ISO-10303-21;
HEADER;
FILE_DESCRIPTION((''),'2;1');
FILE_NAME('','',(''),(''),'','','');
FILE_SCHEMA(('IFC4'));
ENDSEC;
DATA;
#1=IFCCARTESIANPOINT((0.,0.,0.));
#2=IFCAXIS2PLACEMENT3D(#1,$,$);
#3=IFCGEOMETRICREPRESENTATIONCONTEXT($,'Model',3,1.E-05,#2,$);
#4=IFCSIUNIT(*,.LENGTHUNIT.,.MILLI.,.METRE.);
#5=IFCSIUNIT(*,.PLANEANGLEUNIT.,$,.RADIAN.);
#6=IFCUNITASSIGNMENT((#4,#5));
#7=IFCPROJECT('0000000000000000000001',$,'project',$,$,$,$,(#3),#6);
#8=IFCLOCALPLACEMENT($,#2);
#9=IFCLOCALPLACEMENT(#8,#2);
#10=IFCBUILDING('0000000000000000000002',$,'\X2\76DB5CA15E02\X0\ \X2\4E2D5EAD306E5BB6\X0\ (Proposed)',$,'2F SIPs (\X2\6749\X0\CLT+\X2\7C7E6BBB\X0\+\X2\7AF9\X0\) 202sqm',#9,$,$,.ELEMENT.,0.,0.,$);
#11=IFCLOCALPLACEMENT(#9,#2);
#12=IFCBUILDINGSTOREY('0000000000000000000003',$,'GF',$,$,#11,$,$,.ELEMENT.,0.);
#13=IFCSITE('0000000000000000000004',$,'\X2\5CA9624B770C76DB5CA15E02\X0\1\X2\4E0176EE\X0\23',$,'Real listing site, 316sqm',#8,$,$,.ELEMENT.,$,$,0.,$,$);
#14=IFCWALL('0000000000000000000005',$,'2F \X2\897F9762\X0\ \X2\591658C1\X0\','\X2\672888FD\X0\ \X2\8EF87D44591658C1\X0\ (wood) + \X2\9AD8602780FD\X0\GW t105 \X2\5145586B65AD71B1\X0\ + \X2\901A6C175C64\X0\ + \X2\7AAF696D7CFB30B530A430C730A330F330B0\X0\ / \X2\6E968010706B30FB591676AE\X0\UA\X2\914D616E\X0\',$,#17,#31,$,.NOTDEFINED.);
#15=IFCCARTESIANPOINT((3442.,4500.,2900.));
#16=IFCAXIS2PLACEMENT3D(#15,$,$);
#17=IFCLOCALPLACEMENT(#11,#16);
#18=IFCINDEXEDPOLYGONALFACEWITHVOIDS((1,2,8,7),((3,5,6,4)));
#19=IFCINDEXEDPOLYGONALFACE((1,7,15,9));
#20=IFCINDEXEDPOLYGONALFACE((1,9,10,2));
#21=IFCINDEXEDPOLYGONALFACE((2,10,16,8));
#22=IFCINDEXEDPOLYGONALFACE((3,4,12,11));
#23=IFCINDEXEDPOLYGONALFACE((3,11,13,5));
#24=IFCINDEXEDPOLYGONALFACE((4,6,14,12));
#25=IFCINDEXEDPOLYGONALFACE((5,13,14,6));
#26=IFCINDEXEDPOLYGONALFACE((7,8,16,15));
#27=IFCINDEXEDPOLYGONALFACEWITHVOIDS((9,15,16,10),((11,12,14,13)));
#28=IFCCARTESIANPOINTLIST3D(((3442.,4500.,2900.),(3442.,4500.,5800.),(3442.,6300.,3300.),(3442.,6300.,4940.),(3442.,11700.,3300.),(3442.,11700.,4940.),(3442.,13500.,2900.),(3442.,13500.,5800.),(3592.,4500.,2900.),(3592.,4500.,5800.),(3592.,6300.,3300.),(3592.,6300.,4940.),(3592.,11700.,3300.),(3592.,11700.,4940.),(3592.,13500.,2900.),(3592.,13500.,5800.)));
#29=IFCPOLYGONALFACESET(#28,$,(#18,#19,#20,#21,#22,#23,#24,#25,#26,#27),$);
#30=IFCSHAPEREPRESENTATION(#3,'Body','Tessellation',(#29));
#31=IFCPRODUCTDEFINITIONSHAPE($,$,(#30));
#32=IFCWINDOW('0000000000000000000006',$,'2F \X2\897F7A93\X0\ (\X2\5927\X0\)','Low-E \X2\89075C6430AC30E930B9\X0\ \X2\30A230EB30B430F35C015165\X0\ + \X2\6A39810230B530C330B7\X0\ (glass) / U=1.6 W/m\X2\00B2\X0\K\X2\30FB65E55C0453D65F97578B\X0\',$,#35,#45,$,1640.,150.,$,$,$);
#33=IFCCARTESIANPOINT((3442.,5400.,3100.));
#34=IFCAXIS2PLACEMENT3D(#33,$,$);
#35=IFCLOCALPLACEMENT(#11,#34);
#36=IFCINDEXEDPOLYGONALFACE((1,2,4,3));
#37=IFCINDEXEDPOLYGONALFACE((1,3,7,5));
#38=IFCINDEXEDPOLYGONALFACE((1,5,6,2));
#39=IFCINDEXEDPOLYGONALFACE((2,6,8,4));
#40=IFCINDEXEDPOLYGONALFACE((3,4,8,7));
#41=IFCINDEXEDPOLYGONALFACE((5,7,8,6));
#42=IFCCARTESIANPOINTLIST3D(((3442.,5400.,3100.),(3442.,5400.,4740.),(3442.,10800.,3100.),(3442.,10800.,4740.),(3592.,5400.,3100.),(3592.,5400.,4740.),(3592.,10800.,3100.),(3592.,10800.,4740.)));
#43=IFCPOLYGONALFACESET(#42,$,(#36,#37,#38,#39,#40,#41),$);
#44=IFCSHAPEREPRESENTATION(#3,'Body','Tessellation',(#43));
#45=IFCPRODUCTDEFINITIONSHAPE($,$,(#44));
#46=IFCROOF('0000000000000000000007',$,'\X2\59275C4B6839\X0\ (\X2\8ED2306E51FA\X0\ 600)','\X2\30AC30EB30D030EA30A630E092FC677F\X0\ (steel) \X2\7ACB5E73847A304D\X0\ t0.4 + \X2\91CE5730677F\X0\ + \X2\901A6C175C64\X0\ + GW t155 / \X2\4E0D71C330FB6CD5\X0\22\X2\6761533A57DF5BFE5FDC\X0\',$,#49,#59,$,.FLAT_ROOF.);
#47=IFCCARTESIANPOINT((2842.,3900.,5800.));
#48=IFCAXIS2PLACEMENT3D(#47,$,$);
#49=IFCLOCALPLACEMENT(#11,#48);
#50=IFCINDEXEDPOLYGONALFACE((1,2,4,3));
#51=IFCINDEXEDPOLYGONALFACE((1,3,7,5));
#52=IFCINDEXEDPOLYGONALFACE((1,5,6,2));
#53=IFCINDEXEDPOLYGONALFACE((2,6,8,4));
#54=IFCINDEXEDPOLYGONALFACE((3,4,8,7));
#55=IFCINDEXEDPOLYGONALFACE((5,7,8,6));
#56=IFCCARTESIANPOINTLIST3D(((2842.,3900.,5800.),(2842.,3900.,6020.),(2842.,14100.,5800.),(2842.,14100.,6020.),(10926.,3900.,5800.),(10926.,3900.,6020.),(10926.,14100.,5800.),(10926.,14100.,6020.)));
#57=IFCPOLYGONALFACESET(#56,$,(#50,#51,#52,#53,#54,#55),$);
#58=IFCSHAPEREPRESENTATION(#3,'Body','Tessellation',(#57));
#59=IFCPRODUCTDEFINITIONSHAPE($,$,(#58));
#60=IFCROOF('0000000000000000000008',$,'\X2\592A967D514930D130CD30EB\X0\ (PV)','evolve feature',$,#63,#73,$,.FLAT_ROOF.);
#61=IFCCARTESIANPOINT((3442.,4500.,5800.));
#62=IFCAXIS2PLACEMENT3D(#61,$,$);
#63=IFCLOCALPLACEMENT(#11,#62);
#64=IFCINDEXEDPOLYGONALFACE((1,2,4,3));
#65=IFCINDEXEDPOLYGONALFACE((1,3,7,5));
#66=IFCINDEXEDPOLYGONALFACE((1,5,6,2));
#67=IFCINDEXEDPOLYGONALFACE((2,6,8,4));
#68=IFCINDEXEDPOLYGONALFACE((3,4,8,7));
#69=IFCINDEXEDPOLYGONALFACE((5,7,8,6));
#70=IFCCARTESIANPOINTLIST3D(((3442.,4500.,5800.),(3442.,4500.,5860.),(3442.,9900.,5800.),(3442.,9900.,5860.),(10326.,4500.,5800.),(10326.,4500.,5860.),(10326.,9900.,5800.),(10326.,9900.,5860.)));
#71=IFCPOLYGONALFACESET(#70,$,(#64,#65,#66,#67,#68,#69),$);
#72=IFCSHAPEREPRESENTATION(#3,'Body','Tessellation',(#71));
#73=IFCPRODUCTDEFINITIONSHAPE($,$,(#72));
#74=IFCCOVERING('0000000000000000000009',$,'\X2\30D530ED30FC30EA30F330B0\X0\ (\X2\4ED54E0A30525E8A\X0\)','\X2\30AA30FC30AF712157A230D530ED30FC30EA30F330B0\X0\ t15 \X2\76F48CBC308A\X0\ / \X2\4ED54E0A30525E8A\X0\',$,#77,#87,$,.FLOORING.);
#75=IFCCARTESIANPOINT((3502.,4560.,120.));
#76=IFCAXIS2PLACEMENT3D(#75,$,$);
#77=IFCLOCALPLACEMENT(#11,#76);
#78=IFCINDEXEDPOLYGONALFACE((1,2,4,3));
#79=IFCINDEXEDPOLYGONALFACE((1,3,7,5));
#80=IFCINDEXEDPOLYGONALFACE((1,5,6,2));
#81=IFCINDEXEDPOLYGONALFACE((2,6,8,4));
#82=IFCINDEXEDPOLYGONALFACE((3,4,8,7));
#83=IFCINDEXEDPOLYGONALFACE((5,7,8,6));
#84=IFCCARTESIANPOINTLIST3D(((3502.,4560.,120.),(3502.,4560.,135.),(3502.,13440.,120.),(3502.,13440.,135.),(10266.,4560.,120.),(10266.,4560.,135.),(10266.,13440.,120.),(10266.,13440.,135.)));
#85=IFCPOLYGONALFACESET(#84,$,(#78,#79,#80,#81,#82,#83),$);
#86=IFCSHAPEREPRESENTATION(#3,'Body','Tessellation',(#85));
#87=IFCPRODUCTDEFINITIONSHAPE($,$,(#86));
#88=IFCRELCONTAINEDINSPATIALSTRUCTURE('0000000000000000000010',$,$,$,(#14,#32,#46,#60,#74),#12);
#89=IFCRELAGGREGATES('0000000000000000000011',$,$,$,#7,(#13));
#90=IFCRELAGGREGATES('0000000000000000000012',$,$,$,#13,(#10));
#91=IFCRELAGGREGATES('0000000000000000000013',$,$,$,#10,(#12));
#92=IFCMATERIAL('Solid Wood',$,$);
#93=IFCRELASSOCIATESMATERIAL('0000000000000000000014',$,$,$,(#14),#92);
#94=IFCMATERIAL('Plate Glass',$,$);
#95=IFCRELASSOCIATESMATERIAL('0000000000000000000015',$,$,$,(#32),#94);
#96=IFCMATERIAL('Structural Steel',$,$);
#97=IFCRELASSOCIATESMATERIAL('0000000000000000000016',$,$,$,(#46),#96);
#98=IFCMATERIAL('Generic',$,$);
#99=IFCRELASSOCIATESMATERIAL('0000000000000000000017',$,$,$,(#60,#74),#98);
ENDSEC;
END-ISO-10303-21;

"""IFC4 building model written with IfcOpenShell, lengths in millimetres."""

from ifc_helpers import new_model, si_unit, frame, frame_2d, origin, place, context, project, spatial, rectangle, extrude, material, element, fill, save


model = new_model("IFC4")

# Units and contexts
model_context = context("Model", 3, precision=1e-05, world=origin())
ifc_project = project(units=[si_unit("LENGTHUNIT", "METRE", prefix="MILLI"), si_unit("PLANEANGLEUNIT", "RADIAN")], contexts=[model_context])

# Site, building, storey
site_placement = place(None, origin())
site = spatial("IfcSite", under=ifc_project, at=site_placement, Name="岩手県盛岡市1丁目23", ObjectType="Real listing site, 316sqm", CompositionType="ELEMENT", RefElevation=0.0)
building_placement = place(site_placement, origin())
building = spatial("IfcBuilding", under=site, at=building_placement, Name="盛岡市 中庭の家 (Proposed)", ObjectType="2F SIPs (杉CLT+籾殻+竹) 202sqm", CompositionType="ELEMENT", ElevationOfRefHeight=0.0, ElevationOfTerrain=0.0)
storey_placement = place(building_placement, origin())
storey = spatial("IfcBuildingStorey", under=building, at=storey_placement, Name="GF", CompositionType="ELEMENT", Elevation=0.0)

# Shared definitions
ifc_material_1 = material(Name="Solid Wood")

# Shared definitions
ifc_material_2 = material(Name="Plate Glass")
ifc_material_3 = material(Name="Generic")

# Wall, opening, window
wall_1_placement = place(storey_placement, frame((3442.0, 4500.0, 2900.0)))
wall_1 = element("IfcWall", 1, at=wall_1_placement, inside=storey, material=ifc_material_1, Name="2F 西面 外壁", Description="木製 軸組外壁 (wood) + 高性能GW t105 充填断熱 + 通気層 + 窯業系サイディング / 準耐火・外皮UA配慮", PredefinedType="NOTDEFINED", context=model_context, shape_type="SweptSolid", body=[
    extrude(rectangle(XDim=150.0, YDim=9000.0, at=frame_2d((75.0, 4500.0))), frame((3442.0, 4500.0, 2900.0)), (0.0, 0.0, 1.0), 2900.0),
])
opening_1_placement = place(storey_placement, frame((3442.0, 5400.0, 3100.0)))
opening_1 = element("IfcOpeningElement", 2, at=opening_1_placement, cuts=wall_1, PredefinedType="NOTDEFINED", context=model_context, shape_type="SweptSolid", body=[
    extrude(rectangle(XDim=150.0, YDim=5400.0, at=frame_2d((75.0, 2700.0))), frame((3442.0, 5400.0, 3100.0)), (0.0, 0.0, 1.0), 1640.0),
])
window_1_placement = place(storey_placement, frame((3442.0, 5400.0, 3100.0)))
window_1 = element("IfcWindow", 3, at=window_1_placement, inside=storey, material=ifc_material_2, Name="2F 西窓 (大)", Description="Low-E 複層ガラス アルゴン封入 + 樹脂サッシ (glass) / U=1.6 W/m²K・日射取得型", OverallHeight=1640.0, OverallWidth=150.0, context=model_context, shape_type="SweptSolid", body=[
    extrude(rectangle(XDim=150.0, YDim=5400.0, at=frame_2d((75.0, 2700.0))), frame((3442.0, 5400.0, 3100.0)), (0.0, 0.0, 1.0), 1640.0),
])
fill(opening_1, window_1)

# Roofs
ifc_material_4 = material(Name="Structural Steel")
roof_1_placement = place(storey_placement, frame((2842.0, 3900.0, 5800.0)))
element("IfcRoof", 4, at=roof_1_placement, inside=storey, material=ifc_material_4, Name="大屋根 (軒の出 600)", Description="ガルバリウム鋼板 (steel) 立平葺き t0.4 + 野地板 + 通気層 + GW t155 / 不燃・法22条区域対応", PredefinedType="FLAT_ROOF", context=model_context, shape_type="SweptSolid", body=[
    extrude(rectangle(XDim=8084.0, YDim=10200.0, at=frame_2d((4042.0, 5100.0))), frame((2842.0, 3900.0, 5800.0)), (0.0, 0.0, 1.0), 220.0),
])
roof_2_placement = place(storey_placement, frame((3442.0, 4500.0, 5800.0)))
element("IfcRoof", 5, at=roof_2_placement, inside=storey, material=ifc_material_3, Name="太陽光パネル (PV)", Description="evolve feature", PredefinedType="FLAT_ROOF", context=model_context, shape_type="SweptSolid", body=[
    extrude(rectangle(XDim=6884.0, YDim=5400.0, at=frame_2d((3442.0, 2700.0))), frame((3442.0, 4500.0, 5800.0)), (0.0, 0.0, 1.0), 60.0),
])

# Covering
covering_placement = place(storey_placement, frame((3502.0, 4560.0, 120.0)))
element("IfcCovering", 6, at=covering_placement, inside=storey, material=ifc_material_3, Name="フローリング (仕上げ床)", Description="オーク無垢フローリング t15 直貼り / 仕上げ床", PredefinedType="FLOORING", context=model_context, shape_type="SweptSolid", body=[
    extrude(rectangle(XDim=6764.0, YDim=8880.0, at=frame_2d((3382.0, 4440.0))), frame((3502.0, 4560.0, 120.0)), (0.0, 0.0, 1.0), 15.0),
])

save(model, "model.ifc")
